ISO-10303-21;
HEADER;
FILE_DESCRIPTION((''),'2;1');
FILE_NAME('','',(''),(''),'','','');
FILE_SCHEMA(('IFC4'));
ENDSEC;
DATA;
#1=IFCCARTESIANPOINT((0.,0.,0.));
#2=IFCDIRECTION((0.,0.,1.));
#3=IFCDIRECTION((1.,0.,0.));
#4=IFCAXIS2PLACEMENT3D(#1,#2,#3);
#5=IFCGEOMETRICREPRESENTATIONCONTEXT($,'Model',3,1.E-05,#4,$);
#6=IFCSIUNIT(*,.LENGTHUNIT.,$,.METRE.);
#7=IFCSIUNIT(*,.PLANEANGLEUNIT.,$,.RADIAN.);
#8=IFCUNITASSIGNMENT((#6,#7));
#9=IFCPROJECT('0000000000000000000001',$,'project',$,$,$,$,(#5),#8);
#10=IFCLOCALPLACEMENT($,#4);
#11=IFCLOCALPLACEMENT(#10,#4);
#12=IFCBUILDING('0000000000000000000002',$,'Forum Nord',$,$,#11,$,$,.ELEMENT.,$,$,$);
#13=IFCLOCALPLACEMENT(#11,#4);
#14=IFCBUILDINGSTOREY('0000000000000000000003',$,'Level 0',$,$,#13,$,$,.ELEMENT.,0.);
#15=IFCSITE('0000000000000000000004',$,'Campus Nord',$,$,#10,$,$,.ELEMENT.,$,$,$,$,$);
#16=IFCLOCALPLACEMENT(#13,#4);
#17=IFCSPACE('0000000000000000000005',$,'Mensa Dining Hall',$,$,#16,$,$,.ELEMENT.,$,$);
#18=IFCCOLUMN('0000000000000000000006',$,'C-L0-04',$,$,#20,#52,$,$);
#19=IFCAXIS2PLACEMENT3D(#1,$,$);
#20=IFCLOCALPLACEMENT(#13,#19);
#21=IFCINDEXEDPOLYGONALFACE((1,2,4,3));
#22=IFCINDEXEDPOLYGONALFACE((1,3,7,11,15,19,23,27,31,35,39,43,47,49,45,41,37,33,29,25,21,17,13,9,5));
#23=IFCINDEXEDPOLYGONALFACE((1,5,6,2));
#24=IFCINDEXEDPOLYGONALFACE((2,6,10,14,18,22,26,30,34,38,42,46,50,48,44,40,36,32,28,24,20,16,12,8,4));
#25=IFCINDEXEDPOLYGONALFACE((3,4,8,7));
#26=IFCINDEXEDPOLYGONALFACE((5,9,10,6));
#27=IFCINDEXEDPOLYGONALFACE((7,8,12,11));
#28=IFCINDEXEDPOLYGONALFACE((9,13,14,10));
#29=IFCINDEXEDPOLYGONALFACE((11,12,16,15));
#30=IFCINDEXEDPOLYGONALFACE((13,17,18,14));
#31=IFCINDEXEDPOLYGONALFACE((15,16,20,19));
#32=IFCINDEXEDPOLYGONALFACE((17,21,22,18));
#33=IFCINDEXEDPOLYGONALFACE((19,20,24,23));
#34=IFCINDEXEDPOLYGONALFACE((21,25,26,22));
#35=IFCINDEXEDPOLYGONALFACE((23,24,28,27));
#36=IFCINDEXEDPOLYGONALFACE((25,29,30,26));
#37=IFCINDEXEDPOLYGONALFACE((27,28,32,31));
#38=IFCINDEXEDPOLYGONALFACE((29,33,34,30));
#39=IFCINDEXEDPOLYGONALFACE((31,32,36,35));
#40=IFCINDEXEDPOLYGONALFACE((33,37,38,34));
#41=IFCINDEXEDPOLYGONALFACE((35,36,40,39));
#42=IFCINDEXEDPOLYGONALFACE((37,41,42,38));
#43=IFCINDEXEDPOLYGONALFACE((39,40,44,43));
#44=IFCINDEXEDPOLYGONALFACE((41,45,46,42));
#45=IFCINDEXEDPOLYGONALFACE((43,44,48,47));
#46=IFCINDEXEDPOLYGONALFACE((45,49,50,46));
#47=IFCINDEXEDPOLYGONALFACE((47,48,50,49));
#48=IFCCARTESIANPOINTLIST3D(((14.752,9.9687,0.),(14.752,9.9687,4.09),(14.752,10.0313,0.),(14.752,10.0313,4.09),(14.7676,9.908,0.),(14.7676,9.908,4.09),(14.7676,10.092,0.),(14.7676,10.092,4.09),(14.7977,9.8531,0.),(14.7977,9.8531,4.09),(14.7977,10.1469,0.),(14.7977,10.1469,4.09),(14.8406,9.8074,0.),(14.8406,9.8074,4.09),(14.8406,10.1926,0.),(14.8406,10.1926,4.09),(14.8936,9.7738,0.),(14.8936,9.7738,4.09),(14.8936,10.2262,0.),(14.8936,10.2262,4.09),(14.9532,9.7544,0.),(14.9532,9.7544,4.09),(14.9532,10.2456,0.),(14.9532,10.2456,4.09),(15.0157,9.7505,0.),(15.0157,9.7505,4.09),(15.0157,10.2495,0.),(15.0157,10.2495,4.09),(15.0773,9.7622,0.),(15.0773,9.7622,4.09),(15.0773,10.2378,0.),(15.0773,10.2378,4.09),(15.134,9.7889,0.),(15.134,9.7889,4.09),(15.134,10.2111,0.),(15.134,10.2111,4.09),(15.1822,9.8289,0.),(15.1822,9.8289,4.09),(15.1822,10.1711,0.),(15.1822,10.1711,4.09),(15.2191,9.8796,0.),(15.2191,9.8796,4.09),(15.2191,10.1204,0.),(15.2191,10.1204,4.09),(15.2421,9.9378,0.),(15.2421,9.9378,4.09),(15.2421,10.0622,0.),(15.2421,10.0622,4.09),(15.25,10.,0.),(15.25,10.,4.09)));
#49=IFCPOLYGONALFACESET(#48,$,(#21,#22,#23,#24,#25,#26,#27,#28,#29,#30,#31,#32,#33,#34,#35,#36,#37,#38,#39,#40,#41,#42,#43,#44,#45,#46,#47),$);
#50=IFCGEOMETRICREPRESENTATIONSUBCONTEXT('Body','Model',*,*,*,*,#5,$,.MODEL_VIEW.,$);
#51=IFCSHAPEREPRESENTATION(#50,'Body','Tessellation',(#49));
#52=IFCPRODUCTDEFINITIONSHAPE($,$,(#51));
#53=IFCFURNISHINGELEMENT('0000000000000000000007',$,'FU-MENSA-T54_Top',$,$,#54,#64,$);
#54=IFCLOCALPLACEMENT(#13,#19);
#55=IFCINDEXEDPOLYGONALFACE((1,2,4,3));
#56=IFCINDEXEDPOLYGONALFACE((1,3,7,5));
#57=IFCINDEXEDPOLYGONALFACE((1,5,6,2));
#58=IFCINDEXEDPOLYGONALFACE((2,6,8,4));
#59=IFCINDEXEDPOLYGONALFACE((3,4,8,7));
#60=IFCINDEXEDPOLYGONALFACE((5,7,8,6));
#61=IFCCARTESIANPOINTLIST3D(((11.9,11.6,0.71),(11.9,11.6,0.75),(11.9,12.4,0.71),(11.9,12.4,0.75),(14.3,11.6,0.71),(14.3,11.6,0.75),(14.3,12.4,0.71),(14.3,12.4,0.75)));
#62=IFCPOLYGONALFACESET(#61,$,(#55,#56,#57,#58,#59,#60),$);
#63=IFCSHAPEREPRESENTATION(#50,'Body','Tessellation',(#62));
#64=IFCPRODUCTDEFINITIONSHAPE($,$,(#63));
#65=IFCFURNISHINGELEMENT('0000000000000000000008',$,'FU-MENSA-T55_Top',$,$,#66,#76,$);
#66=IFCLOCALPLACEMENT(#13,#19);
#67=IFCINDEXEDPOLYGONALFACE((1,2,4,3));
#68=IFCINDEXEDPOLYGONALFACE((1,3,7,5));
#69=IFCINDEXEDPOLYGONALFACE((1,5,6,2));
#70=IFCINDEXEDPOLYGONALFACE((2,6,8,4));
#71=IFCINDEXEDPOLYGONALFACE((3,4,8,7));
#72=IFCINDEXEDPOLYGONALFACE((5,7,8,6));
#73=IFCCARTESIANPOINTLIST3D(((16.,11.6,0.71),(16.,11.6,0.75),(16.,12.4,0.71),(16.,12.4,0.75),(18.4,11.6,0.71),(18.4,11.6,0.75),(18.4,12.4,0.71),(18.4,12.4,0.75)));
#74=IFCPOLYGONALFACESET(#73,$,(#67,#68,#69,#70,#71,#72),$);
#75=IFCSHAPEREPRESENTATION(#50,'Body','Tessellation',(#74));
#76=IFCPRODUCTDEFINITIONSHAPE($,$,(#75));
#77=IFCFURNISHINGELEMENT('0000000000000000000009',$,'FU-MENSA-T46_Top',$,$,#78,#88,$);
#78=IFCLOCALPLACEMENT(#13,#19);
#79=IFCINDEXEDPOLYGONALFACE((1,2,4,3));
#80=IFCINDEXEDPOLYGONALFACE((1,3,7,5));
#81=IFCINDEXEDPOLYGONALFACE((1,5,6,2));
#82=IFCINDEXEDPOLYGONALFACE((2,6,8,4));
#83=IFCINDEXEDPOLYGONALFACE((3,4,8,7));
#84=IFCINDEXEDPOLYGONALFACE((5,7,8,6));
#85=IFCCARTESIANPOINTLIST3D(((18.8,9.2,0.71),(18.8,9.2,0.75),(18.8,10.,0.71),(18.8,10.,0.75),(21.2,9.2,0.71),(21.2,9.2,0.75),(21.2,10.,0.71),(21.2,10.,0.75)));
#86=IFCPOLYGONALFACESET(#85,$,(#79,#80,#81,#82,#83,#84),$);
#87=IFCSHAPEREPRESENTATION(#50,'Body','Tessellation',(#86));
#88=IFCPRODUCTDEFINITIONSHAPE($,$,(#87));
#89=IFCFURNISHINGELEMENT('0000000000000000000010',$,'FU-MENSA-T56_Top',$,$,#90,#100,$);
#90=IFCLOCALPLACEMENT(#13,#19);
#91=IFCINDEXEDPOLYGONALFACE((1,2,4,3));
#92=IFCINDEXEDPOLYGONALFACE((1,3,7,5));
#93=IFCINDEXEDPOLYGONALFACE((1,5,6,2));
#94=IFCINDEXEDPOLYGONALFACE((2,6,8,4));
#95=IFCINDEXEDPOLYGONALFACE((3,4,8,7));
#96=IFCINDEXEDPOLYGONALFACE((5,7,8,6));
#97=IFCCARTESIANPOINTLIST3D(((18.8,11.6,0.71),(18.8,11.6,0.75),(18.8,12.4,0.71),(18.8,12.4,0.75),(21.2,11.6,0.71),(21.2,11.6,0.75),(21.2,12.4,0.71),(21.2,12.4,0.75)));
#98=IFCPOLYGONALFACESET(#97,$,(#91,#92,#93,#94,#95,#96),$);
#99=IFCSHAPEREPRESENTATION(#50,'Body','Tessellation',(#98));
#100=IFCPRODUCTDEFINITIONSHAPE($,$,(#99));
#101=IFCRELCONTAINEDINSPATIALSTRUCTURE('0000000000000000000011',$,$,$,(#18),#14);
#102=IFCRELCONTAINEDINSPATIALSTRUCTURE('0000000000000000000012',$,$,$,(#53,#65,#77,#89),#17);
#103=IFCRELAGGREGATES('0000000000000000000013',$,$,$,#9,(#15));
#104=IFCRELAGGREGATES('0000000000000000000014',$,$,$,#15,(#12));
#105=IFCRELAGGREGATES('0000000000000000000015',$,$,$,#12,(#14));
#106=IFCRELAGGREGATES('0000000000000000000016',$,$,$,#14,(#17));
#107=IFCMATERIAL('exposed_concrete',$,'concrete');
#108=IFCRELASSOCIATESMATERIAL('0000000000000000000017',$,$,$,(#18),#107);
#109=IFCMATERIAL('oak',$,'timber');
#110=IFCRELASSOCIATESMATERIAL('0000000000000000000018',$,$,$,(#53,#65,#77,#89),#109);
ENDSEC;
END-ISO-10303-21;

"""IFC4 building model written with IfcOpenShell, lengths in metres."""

from ifc_helpers import new_model, si_unit, frame, frame_2d, origin_with_axes, origin_2d_with_axis, place, context, subcontext, project, spatial, rectangle, circle, extrude, material, element, save


model = new_model("IFC4")

# Units and contexts
model_context = context("Model", 3, precision=1e-05, world=origin_with_axes())
body_context = subcontext(model_context, "Body", "Model", "MODEL_VIEW")
ifc_project = project(units=[si_unit("LENGTHUNIT", "METRE"), si_unit("PLANEANGLEUNIT", "RADIAN")], contexts=[model_context])

# Site, building, storey
site_placement = place(None, origin_with_axes())
site = spatial("IfcSite", under=ifc_project, at=site_placement, Name="Campus Nord", CompositionType="ELEMENT")
building_placement = place(site_placement, origin_with_axes())
building = spatial("IfcBuilding", under=site, at=building_placement, Name="Forum Nord", CompositionType="ELEMENT")
storey_placement = place(building_placement, origin_with_axes())
storey = spatial("IfcBuildingStorey", under=building, at=storey_placement, Name="Level 0", CompositionType="ELEMENT", Elevation=0.0)

# Column
ifc_material_1 = material(Name="exposed_concrete", Category="concrete")
column_placement = place(storey_placement, frame((15.0, 10.0, 0.0), z_axis=(0.0, 0.0, 1.0), x_axis=(1.0, 0.0, 0.0)))
element("IfcColumn", 1, at=column_placement, inside=storey, material=ifc_material_1, Name="C-L0-04", context=body_context, shape_type="SweptSolid", body=[
    extrude(circle(Radius=0.25, at=origin_2d_with_axis()), origin_with_axes(), (0.0, 0.0, 1.0), 4.09),
])

# Shared definitions
space_placement = place(storey_placement, origin_with_axes())
space = spatial("IfcSpace", under=storey, at=space_placement, Name="Mensa Dining Hall", CompositionType="ELEMENT")

# Furnishing elements
ifc_material_2 = material(Name="oak", Category="timber")
furnishing_1_placement = place(storey_placement, frame((11.9, 11.6, 0.0), z_axis=(0.0, 0.0, 1.0), x_axis=(1.0, 0.0, 0.0)))
element("IfcFurnishingElement", 2, at=furnishing_1_placement, inside=space, material=ifc_material_2, Name="FU-MENSA-T54_Top", context=body_context, shape_type="SweptSolid", body=[
    extrude(rectangle(XDim=2.4, YDim=0.8, at=frame_2d((1.2, 0.4), x_axis=(1.0, 0.0))), frame((0.0, 0.0, 0.71), z_axis=(0.0, 0.0, 1.0), x_axis=(1.0, 0.0, 0.0)), (0.0, 0.0, 1.0), 0.04),
])
furnishing_2_placement = place(storey_placement, frame((16.0, 11.6, 0.0), z_axis=(0.0, 0.0, 1.0), x_axis=(1.0, 0.0, 0.0)))
element("IfcFurnishingElement", 3, at=furnishing_2_placement, inside=space, material=ifc_material_2, Name="FU-MENSA-T55_Top", context=body_context, shape_type="SweptSolid", body=[
    extrude(rectangle(XDim=2.4, YDim=0.8, at=frame_2d((1.2, 0.4), x_axis=(1.0, 0.0))), frame((0.0, 0.0, 0.71), z_axis=(0.0, 0.0, 1.0), x_axis=(1.0, 0.0, 0.0)), (0.0, 0.0, 1.0), 0.04),
])
furnishing_3_placement = place(storey_placement, frame((18.8, 9.2, 0.0), z_axis=(0.0, 0.0, 1.0), x_axis=(1.0, 0.0, 0.0)))
element("IfcFurnishingElement", 4, at=furnishing_3_placement, inside=space, material=ifc_material_2, Name="FU-MENSA-T46_Top", context=body_context, shape_type="SweptSolid", body=[
    extrude(rectangle(XDim=2.4, YDim=0.8, at=frame_2d((1.2, 0.4), x_axis=(1.0, 0.0))), frame((0.0, 0.0, 0.71), z_axis=(0.0, 0.0, 1.0), x_axis=(1.0, 0.0, 0.0)), (0.0, 0.0, 1.0), 0.04),
])
furnishing_4_placement = place(storey_placement, frame((18.8, 11.6, 0.0), z_axis=(0.0, 0.0, 1.0), x_axis=(1.0, 0.0, 0.0)))
element("IfcFurnishingElement", 5, at=furnishing_4_placement, inside=space, material=ifc_material_2, Name="FU-MENSA-T56_Top", context=body_context, shape_type="SweptSolid", body=[
    extrude(rectangle(XDim=2.4, YDim=0.8, at=frame_2d((1.2, 0.4), x_axis=(1.0, 0.0))), frame((0.0, 0.0, 0.71), z_axis=(0.0, 0.0, 1.0), x_axis=(1.0, 0.0, 0.0)), (0.0, 0.0, 1.0), 0.04),
])

save(model, "model.ifc")
